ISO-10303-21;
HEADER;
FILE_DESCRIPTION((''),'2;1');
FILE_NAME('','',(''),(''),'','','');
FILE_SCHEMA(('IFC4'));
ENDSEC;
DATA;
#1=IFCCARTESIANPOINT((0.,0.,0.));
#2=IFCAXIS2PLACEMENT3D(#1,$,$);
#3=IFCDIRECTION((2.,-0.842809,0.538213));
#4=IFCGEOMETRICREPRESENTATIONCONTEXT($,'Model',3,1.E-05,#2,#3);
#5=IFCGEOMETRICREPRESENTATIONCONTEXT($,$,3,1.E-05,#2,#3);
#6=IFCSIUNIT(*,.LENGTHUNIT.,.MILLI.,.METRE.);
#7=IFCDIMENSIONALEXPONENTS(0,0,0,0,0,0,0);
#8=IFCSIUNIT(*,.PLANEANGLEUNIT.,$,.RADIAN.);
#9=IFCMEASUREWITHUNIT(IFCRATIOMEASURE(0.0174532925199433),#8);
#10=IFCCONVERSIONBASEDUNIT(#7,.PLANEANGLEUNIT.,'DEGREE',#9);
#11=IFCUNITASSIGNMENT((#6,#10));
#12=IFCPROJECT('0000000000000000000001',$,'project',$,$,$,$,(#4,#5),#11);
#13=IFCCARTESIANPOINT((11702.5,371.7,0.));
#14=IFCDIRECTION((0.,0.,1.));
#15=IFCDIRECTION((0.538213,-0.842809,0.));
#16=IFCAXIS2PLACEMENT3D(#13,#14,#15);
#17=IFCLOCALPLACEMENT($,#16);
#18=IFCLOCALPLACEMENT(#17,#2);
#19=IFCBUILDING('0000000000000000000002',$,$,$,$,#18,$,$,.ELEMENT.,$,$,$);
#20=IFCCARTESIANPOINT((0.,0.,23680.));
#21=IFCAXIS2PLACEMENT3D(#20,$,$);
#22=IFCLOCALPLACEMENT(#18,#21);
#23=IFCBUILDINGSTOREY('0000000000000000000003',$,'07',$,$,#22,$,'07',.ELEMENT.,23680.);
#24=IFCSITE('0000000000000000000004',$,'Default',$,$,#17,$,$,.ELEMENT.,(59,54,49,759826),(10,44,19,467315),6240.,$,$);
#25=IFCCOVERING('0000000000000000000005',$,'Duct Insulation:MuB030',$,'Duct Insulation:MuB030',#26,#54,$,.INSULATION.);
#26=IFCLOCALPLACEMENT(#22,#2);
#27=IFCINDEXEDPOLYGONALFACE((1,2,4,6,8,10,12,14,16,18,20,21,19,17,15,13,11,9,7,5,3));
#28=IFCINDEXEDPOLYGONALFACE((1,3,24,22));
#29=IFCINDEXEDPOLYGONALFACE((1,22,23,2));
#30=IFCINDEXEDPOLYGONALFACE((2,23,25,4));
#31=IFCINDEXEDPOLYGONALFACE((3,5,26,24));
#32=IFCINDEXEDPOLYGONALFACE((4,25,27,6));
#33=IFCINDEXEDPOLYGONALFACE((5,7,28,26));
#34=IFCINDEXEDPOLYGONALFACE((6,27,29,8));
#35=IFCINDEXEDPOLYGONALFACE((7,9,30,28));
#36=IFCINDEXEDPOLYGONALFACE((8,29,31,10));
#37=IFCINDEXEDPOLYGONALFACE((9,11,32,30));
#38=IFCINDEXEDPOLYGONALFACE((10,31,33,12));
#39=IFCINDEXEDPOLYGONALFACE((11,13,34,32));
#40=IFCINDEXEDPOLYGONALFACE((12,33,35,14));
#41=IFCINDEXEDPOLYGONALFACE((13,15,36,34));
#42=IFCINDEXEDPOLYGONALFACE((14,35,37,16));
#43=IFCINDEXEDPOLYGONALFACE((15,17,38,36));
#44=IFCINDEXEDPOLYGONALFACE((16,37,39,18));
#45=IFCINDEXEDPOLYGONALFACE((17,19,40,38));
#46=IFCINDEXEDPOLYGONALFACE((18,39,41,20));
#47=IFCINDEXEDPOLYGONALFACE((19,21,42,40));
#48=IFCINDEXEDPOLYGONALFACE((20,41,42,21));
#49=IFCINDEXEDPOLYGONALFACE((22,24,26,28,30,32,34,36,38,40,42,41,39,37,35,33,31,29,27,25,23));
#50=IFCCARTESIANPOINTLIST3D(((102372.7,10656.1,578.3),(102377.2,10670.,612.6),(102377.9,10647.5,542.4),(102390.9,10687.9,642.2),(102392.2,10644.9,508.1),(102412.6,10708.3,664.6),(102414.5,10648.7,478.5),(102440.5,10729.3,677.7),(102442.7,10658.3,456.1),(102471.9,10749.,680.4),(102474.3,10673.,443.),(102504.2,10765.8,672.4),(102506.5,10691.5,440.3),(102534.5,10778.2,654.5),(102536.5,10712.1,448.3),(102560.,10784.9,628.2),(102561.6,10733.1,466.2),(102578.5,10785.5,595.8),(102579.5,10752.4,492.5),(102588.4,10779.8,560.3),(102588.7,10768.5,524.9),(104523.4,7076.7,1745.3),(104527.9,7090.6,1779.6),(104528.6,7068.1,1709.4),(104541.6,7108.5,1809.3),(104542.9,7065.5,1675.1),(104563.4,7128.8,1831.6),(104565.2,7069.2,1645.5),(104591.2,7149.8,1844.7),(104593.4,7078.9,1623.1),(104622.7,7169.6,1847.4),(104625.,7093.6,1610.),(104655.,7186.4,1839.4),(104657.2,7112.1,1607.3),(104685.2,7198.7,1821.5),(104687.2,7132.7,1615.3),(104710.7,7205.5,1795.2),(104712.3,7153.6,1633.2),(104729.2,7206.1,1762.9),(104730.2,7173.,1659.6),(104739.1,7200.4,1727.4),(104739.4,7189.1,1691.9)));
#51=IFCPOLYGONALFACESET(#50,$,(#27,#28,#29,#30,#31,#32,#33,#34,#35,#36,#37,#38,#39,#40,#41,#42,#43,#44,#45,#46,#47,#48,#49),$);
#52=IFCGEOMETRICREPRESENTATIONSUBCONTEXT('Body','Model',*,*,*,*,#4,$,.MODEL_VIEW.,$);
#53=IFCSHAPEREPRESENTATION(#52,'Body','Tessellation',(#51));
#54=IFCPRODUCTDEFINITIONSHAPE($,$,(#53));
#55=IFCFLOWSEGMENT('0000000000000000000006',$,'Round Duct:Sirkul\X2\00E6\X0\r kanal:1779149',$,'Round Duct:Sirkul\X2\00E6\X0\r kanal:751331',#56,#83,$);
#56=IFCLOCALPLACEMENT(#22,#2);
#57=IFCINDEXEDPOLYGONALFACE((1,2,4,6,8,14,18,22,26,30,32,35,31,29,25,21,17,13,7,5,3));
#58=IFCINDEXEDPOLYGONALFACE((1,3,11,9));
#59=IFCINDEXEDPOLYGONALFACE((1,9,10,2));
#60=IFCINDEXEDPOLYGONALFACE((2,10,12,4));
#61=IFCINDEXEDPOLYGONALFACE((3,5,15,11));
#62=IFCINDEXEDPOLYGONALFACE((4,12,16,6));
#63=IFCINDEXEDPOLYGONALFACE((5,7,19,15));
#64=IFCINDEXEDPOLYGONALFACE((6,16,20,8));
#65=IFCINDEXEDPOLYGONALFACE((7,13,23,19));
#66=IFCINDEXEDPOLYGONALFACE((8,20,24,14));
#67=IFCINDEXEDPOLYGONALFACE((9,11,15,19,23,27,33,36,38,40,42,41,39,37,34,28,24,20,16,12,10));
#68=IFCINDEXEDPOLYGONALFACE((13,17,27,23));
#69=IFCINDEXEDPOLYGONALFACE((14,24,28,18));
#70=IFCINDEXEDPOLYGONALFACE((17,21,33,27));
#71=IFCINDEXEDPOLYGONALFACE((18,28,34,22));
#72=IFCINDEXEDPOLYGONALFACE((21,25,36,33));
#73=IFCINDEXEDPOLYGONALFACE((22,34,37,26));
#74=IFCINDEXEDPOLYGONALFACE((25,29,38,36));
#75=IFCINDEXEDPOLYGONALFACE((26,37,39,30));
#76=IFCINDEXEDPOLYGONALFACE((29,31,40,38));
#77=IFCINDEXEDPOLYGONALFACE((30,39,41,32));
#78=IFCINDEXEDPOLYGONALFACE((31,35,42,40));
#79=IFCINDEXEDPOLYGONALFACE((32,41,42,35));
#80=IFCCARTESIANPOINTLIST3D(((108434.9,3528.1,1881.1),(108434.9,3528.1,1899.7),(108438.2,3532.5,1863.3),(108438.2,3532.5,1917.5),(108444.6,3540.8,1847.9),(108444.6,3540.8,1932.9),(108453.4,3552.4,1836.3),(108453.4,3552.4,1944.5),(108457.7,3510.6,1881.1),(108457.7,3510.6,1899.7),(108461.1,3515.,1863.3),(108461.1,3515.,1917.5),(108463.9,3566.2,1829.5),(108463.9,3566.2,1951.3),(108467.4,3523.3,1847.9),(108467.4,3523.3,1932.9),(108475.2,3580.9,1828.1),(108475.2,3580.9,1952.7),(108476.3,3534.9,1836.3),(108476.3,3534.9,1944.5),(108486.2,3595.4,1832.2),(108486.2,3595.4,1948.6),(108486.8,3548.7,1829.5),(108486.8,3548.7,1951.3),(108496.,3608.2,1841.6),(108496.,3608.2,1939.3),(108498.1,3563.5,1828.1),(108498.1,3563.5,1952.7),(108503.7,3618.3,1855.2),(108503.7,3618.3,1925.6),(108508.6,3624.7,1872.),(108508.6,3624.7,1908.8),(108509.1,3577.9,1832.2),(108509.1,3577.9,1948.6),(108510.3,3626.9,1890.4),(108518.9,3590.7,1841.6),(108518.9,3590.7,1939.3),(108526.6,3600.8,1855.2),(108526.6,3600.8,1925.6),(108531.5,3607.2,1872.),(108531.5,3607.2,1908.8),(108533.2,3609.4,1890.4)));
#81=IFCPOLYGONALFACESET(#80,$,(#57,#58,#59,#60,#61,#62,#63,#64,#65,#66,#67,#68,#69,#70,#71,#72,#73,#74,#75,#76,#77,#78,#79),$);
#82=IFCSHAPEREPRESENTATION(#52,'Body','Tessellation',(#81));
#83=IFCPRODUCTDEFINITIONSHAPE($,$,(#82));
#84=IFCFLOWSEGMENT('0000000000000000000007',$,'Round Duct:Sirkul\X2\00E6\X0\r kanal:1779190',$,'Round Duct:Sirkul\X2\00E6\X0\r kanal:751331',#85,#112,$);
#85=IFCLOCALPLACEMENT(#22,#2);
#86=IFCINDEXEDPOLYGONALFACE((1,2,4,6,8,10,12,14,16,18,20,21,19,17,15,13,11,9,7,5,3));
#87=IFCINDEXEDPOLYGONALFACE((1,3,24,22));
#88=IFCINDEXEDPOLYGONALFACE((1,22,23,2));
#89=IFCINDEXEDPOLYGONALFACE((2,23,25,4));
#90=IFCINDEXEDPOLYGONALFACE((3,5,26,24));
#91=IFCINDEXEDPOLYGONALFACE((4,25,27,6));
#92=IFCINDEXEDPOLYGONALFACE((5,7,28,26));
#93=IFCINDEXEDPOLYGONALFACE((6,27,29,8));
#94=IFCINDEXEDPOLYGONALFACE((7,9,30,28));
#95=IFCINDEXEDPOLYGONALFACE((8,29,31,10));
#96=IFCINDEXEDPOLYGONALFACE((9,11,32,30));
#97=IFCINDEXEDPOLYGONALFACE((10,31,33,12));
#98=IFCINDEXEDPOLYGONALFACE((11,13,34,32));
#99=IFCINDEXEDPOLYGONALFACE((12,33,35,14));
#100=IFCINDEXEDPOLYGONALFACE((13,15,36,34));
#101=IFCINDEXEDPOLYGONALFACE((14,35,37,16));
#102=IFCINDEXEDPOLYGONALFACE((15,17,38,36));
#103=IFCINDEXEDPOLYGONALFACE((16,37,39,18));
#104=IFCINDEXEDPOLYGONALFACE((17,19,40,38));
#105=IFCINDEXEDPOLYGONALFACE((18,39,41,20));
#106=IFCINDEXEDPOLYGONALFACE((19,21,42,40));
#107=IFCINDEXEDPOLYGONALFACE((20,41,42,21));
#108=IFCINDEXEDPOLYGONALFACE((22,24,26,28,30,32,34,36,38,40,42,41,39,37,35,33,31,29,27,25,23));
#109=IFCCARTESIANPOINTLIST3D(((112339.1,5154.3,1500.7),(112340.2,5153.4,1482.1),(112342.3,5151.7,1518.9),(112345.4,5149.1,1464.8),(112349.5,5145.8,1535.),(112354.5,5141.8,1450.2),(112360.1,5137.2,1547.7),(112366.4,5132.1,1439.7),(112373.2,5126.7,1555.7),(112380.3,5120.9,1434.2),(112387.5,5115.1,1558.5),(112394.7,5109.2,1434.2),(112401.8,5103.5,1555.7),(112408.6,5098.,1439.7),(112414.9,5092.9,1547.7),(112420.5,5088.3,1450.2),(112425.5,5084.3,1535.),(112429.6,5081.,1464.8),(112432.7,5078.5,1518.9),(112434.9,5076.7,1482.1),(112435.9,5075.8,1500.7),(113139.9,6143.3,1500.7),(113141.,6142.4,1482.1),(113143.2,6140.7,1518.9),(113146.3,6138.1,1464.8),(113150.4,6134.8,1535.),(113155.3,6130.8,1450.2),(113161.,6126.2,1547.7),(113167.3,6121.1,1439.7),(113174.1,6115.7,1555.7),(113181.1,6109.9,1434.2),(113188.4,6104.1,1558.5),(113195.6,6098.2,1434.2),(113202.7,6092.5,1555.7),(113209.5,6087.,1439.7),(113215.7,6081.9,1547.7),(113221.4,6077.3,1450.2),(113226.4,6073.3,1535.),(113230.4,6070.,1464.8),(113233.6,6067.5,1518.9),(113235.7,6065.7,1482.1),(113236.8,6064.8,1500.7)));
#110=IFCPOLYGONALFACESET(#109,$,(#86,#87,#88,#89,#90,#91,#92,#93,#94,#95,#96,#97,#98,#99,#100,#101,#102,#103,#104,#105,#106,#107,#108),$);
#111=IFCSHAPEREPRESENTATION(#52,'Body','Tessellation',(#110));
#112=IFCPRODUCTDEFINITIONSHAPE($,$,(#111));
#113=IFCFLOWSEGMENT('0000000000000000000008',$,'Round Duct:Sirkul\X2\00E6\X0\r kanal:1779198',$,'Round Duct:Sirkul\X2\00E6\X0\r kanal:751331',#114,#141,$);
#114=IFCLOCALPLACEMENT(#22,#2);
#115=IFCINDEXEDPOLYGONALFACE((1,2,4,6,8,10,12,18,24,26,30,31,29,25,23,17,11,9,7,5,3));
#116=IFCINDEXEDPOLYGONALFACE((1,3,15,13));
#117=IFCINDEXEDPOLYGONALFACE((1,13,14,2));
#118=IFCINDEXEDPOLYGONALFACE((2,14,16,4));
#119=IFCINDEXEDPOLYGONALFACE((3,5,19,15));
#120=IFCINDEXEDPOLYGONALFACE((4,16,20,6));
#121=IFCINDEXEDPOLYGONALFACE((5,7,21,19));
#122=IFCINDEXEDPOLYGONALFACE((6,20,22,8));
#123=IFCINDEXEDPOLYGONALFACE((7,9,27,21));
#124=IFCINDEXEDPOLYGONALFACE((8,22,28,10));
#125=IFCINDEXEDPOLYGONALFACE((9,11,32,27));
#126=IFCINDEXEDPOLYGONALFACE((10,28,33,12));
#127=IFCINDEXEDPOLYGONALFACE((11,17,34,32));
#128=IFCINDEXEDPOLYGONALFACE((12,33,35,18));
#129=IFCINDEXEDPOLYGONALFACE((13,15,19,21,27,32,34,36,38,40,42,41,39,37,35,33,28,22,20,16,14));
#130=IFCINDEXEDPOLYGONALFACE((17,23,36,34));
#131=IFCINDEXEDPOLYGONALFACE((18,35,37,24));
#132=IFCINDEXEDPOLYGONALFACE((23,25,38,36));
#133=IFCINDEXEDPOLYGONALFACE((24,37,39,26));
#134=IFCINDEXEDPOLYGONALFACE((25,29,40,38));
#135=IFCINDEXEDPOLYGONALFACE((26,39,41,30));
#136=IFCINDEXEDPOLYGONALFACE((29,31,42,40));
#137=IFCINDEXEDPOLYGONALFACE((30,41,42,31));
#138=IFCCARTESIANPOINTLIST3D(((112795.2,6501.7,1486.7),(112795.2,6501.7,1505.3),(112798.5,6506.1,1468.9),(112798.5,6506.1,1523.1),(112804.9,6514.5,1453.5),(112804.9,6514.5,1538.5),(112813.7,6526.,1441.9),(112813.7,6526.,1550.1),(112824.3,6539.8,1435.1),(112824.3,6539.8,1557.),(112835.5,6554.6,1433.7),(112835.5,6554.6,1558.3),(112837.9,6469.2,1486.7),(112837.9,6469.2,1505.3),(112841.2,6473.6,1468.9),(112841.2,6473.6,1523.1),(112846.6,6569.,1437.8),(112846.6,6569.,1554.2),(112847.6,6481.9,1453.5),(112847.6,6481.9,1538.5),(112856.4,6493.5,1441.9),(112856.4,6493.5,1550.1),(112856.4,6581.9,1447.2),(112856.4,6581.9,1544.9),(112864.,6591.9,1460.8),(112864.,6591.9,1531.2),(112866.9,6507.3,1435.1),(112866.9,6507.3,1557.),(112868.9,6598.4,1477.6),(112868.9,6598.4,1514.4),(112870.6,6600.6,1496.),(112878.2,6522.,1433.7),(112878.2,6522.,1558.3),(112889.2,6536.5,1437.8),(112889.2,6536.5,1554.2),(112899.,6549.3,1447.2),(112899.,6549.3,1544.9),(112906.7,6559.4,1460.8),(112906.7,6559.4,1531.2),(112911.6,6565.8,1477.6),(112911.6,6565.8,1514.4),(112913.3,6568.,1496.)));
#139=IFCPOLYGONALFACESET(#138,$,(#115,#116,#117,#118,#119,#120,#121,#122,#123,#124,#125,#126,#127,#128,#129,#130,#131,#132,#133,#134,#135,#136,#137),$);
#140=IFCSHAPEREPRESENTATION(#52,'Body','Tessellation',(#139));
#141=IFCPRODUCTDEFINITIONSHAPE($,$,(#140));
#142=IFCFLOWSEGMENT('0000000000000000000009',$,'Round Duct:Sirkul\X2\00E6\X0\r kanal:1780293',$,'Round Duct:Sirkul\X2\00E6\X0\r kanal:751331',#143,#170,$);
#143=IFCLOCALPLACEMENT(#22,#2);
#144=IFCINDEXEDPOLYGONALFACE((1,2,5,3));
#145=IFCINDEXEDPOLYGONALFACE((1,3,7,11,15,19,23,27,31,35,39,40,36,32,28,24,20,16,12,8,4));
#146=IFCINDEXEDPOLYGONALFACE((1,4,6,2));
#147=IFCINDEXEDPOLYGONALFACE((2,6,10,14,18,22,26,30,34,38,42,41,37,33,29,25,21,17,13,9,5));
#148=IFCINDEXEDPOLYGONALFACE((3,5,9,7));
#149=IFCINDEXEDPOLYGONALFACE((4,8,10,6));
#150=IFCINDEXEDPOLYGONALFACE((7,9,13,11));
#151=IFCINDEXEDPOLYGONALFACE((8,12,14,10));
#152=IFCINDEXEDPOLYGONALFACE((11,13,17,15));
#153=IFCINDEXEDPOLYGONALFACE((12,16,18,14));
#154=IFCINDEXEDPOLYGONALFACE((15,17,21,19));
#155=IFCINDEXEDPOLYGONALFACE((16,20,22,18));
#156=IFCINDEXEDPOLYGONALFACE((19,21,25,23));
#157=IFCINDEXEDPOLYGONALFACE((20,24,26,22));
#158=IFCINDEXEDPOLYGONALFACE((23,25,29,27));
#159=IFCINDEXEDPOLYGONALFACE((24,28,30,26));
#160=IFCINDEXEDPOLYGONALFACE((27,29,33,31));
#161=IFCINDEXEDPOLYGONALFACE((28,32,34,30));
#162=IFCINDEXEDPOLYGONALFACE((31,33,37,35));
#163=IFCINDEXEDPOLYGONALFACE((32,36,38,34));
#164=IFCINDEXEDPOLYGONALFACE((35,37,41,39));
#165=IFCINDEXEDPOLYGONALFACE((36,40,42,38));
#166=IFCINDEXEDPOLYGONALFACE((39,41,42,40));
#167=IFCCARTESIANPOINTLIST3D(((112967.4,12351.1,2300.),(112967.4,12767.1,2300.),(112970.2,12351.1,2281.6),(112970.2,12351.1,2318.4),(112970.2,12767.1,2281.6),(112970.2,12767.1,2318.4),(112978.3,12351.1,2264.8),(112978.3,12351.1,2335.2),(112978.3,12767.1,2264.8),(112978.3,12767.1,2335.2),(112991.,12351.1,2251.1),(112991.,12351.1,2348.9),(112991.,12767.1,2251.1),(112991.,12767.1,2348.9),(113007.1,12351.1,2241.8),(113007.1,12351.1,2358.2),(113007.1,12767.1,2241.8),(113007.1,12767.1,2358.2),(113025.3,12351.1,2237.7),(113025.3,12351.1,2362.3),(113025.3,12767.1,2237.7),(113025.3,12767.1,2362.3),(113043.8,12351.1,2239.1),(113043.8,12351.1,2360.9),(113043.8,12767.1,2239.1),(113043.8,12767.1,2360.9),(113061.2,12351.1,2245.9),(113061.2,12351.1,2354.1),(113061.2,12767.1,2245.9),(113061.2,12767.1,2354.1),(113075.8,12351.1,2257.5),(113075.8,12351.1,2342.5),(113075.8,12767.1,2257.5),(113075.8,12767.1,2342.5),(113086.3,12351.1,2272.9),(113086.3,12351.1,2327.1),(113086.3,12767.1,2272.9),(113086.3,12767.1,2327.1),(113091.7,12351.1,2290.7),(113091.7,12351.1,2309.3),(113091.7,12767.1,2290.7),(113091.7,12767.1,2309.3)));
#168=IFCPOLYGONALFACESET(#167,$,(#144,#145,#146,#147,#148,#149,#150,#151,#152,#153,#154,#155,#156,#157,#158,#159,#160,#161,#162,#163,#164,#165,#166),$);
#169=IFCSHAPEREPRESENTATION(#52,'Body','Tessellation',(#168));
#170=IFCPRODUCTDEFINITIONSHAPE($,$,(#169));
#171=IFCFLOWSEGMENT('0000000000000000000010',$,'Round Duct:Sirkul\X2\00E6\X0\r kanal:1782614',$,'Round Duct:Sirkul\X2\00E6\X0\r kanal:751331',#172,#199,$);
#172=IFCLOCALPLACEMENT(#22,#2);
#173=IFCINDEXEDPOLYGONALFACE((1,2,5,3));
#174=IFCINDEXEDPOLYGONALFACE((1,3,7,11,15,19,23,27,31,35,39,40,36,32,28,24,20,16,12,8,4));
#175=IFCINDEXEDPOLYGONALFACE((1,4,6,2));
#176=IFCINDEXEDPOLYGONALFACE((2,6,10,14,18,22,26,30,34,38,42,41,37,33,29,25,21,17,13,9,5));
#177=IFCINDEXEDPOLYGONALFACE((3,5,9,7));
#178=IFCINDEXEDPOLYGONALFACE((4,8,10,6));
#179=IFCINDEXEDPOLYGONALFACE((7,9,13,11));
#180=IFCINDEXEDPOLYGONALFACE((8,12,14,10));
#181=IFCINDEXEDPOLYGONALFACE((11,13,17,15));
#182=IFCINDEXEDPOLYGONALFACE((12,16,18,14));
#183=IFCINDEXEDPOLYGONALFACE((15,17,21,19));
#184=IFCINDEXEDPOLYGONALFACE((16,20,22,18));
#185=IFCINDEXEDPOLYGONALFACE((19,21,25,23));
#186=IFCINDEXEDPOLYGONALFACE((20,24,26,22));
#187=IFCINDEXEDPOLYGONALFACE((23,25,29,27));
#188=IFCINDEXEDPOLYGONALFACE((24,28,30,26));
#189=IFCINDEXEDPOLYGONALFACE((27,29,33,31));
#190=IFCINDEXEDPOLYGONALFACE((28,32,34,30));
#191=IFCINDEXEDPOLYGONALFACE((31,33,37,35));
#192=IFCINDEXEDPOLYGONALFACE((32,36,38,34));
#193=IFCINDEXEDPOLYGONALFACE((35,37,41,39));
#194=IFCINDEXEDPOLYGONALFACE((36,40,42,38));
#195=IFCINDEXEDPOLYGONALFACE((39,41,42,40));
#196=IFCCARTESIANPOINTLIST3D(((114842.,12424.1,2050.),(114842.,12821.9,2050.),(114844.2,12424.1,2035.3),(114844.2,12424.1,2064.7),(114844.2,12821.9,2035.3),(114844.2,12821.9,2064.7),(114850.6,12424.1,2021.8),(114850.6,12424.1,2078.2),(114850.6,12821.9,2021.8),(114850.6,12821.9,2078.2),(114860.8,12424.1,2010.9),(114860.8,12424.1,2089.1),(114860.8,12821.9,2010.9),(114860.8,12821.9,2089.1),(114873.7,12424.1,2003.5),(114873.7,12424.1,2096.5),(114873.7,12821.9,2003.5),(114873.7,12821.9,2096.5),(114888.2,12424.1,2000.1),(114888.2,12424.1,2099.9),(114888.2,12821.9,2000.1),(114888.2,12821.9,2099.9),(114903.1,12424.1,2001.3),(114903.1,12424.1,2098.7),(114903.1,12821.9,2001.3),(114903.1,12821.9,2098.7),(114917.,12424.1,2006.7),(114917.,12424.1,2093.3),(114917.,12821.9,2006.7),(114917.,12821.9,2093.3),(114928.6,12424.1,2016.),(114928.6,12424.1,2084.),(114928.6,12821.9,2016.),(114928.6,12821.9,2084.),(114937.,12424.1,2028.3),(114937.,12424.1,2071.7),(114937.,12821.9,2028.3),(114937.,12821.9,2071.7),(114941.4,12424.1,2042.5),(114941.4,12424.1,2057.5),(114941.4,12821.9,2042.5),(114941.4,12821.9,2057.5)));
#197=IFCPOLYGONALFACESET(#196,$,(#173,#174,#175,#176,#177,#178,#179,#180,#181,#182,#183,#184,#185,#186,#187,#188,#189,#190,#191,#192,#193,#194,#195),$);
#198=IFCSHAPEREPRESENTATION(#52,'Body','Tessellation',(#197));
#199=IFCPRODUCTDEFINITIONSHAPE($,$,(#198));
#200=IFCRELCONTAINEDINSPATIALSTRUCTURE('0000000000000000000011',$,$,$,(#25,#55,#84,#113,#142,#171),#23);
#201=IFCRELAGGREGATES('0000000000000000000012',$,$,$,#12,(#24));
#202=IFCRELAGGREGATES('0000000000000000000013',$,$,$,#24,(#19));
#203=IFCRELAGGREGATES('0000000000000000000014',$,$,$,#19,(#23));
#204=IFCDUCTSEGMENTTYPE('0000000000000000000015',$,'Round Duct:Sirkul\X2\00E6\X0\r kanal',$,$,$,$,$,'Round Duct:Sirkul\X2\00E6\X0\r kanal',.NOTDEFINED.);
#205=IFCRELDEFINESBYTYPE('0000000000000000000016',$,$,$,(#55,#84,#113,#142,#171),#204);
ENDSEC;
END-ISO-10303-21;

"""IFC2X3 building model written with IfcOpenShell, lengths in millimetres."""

from ifc_helpers import new_model, entity, si_unit, converted_unit, direction, frame, frame_2d, origin, origin_2d_with_axis, place, context, subcontext, project, spatial, circle, extrude, type_object, element, save


model = new_model("IFC2X3")

# Units and contexts
model_context = context("Model", 3, precision=1e-05, world=origin(), true_north=direction((2.0, -0.842809, 0.538213)))
context_of_model = context(None, 3, precision=1e-05, world=origin(), true_north=direction((2.0, -0.842809, 0.538213)))
body_context = subcontext(model_context, "Body", "Model", "MODEL_VIEW")
ifc_project = project(units=[si_unit("LENGTHUNIT", "METRE", prefix="MILLI"), converted_unit("PLANEANGLEUNIT", "DEGREE", entity("IfcRatioMeasure", 0.0174532925199433), si_unit("PLANEANGLEUNIT", "RADIAN"), dimensions=[0, 0, 0, 0, 0, 0, 0])], contexts=[model_context, context_of_model])

# Site, building, storey
site_placement = place(None, frame((11702.5, 371.7, 0.0), z_axis=(0.0, 0.0, 1.0), x_axis=(0.538213, -0.842809, 0.0)))
site = spatial("IfcSite", under=ifc_project, at=site_placement, Name="Default", CompositionType="ELEMENT", RefLatitude=(59, 54, 49, 759826), RefLongitude=(10, 44, 19, 467315), RefElevation=6240.0)
building_placement = place(site_placement, origin())
building = spatial("IfcBuilding", under=site, at=building_placement, CompositionType="ELEMENT")
storey_placement = place(building_placement, frame((0.0, 0.0, 23680.0)))
storey = spatial("IfcBuildingStorey", under=building, at=storey_placement, Name="07", LongName="07", CompositionType="ELEMENT", Elevation=23680.0)

# Covering
covering_1_placement = place(storey_placement, origin())
element("IfcCovering", 1, at=covering_1_placement, inside=storey, Name="Duct Insulation:MuB030", ObjectType="Duct Insulation:MuB030", PredefinedType="INSULATION", context=body_context, shape_type="SweptSolid", body=[
    extrude(circle(Radius=125.0, at=frame_2d((0.0, 0.0), x_axis=(1.0, 0.0))), frame((104631.9, 7136.0, 1727.4), z_axis=(-0.496031, 0.825535, -0.269156), x_axis=(0.857167, 0.515038, 0.0)), (0.0, 0.0, 1.0), 4335.9),
])

# Flow segments
duct_segment_type = type_object("IfcDuctSegmentType", Name="Round Duct:Sirkulær kanal", ElementType="Round Duct:Sirkulær kanal", PredefinedType="NOTDEFINED")
flow_segment_1_placement = place(storey_placement, origin())
element("IfcFlowSegment", 2, at=flow_segment_1_placement, inside=storey, type_object=duct_segment_type, Name="Round Duct:Sirkulær kanal:1779149", ObjectType="Round Duct:Sirkulær kanal:751331", context=body_context, shape_type="SweptSolid", body=[
    extrude(circle(Radius=62.5, at=frame_2d((0.0, 0.0), x_axis=(1.0, 0.0))), frame((108495.2, 3559.8, 1890.4), z_axis=(-0.794938, 0.60669, 0.0), x_axis=(0.60669, 0.794938, 0.0)), (0.0, 0.0, 1.0), 28.8),
])
flow_segment_2_placement = place(storey_placement, origin())
element("IfcFlowSegment", 3, at=flow_segment_2_placement, inside=storey, type_object=duct_segment_type, Name="Round Duct:Sirkulær kanal:1779190", ObjectType="Round Duct:Sirkulær kanal:751331", context=body_context, shape_type="SweptSolid", body=[
    extrude(circle(Radius=62.5, at=origin_2d_with_axis()), frame((112387.5, 5115.1, 1496.0), z_axis=(0.62932, 0.777146, 0.0), x_axis=(0.0, 0.0, 1.0)), (0.0, 0.0, 1.0), 1272.6),
])
flow_segment_3_placement = place(storey_placement, origin())
element("IfcFlowSegment", 4, at=flow_segment_3_placement, inside=storey, type_object=duct_segment_type, Name="Round Duct:Sirkulær kanal:1779198", ObjectType="Round Duct:Sirkulær kanal:751331", context=body_context, shape_type="SweptSolid", body=[
    extrude(circle(Radius=62.5, at=frame_2d((0.0, 0.0), x_axis=(1.0, 0.0))), frame((112875.4, 6518.3, 1496.0), z_axis=(-0.794938, 0.60669, 0.0), x_axis=(0.60669, 0.794938, 0.0)), (0.0, 0.0, 1.0), 53.6),
])
flow_segment_4_placement = place(storey_placement, origin())
element("IfcFlowSegment", 5, at=flow_segment_4_placement, inside=storey, type_object=duct_segment_type, Name="Round Duct:Sirkulær kanal:1780293", ObjectType="Round Duct:Sirkulær kanal:751331", context=body_context, shape_type="SweptSolid", body=[
    extrude(circle(Radius=62.5, at=origin_2d_with_axis()), frame((113029.9, 12351.1, 2300.0), z_axis=(0.0, 1.0, 0.0), x_axis=(-1.0, 0.0, 0.0)), (0.0, 0.0, 1.0), 416.0),
])
flow_segment_5_placement = place(storey_placement, origin())
element("IfcFlowSegment", 6, at=flow_segment_5_placement, inside=storey, type_object=duct_segment_type, Name="Round Duct:Sirkulær kanal:1782614", ObjectType="Round Duct:Sirkulær kanal:751331", context=body_context, shape_type="SweptSolid", body=[
    extrude(circle(Radius=50.0, at=frame_2d((0.0, 0.0), x_axis=(1.0, 0.0))), frame((114892.0, 12424.1, 2050.0), z_axis=(0.0, 1.0, 0.0), x_axis=(-1.0, 0.0, 0.0)), (0.0, 0.0, 1.0), 397.9),
])

save(model, "model.ifc")
